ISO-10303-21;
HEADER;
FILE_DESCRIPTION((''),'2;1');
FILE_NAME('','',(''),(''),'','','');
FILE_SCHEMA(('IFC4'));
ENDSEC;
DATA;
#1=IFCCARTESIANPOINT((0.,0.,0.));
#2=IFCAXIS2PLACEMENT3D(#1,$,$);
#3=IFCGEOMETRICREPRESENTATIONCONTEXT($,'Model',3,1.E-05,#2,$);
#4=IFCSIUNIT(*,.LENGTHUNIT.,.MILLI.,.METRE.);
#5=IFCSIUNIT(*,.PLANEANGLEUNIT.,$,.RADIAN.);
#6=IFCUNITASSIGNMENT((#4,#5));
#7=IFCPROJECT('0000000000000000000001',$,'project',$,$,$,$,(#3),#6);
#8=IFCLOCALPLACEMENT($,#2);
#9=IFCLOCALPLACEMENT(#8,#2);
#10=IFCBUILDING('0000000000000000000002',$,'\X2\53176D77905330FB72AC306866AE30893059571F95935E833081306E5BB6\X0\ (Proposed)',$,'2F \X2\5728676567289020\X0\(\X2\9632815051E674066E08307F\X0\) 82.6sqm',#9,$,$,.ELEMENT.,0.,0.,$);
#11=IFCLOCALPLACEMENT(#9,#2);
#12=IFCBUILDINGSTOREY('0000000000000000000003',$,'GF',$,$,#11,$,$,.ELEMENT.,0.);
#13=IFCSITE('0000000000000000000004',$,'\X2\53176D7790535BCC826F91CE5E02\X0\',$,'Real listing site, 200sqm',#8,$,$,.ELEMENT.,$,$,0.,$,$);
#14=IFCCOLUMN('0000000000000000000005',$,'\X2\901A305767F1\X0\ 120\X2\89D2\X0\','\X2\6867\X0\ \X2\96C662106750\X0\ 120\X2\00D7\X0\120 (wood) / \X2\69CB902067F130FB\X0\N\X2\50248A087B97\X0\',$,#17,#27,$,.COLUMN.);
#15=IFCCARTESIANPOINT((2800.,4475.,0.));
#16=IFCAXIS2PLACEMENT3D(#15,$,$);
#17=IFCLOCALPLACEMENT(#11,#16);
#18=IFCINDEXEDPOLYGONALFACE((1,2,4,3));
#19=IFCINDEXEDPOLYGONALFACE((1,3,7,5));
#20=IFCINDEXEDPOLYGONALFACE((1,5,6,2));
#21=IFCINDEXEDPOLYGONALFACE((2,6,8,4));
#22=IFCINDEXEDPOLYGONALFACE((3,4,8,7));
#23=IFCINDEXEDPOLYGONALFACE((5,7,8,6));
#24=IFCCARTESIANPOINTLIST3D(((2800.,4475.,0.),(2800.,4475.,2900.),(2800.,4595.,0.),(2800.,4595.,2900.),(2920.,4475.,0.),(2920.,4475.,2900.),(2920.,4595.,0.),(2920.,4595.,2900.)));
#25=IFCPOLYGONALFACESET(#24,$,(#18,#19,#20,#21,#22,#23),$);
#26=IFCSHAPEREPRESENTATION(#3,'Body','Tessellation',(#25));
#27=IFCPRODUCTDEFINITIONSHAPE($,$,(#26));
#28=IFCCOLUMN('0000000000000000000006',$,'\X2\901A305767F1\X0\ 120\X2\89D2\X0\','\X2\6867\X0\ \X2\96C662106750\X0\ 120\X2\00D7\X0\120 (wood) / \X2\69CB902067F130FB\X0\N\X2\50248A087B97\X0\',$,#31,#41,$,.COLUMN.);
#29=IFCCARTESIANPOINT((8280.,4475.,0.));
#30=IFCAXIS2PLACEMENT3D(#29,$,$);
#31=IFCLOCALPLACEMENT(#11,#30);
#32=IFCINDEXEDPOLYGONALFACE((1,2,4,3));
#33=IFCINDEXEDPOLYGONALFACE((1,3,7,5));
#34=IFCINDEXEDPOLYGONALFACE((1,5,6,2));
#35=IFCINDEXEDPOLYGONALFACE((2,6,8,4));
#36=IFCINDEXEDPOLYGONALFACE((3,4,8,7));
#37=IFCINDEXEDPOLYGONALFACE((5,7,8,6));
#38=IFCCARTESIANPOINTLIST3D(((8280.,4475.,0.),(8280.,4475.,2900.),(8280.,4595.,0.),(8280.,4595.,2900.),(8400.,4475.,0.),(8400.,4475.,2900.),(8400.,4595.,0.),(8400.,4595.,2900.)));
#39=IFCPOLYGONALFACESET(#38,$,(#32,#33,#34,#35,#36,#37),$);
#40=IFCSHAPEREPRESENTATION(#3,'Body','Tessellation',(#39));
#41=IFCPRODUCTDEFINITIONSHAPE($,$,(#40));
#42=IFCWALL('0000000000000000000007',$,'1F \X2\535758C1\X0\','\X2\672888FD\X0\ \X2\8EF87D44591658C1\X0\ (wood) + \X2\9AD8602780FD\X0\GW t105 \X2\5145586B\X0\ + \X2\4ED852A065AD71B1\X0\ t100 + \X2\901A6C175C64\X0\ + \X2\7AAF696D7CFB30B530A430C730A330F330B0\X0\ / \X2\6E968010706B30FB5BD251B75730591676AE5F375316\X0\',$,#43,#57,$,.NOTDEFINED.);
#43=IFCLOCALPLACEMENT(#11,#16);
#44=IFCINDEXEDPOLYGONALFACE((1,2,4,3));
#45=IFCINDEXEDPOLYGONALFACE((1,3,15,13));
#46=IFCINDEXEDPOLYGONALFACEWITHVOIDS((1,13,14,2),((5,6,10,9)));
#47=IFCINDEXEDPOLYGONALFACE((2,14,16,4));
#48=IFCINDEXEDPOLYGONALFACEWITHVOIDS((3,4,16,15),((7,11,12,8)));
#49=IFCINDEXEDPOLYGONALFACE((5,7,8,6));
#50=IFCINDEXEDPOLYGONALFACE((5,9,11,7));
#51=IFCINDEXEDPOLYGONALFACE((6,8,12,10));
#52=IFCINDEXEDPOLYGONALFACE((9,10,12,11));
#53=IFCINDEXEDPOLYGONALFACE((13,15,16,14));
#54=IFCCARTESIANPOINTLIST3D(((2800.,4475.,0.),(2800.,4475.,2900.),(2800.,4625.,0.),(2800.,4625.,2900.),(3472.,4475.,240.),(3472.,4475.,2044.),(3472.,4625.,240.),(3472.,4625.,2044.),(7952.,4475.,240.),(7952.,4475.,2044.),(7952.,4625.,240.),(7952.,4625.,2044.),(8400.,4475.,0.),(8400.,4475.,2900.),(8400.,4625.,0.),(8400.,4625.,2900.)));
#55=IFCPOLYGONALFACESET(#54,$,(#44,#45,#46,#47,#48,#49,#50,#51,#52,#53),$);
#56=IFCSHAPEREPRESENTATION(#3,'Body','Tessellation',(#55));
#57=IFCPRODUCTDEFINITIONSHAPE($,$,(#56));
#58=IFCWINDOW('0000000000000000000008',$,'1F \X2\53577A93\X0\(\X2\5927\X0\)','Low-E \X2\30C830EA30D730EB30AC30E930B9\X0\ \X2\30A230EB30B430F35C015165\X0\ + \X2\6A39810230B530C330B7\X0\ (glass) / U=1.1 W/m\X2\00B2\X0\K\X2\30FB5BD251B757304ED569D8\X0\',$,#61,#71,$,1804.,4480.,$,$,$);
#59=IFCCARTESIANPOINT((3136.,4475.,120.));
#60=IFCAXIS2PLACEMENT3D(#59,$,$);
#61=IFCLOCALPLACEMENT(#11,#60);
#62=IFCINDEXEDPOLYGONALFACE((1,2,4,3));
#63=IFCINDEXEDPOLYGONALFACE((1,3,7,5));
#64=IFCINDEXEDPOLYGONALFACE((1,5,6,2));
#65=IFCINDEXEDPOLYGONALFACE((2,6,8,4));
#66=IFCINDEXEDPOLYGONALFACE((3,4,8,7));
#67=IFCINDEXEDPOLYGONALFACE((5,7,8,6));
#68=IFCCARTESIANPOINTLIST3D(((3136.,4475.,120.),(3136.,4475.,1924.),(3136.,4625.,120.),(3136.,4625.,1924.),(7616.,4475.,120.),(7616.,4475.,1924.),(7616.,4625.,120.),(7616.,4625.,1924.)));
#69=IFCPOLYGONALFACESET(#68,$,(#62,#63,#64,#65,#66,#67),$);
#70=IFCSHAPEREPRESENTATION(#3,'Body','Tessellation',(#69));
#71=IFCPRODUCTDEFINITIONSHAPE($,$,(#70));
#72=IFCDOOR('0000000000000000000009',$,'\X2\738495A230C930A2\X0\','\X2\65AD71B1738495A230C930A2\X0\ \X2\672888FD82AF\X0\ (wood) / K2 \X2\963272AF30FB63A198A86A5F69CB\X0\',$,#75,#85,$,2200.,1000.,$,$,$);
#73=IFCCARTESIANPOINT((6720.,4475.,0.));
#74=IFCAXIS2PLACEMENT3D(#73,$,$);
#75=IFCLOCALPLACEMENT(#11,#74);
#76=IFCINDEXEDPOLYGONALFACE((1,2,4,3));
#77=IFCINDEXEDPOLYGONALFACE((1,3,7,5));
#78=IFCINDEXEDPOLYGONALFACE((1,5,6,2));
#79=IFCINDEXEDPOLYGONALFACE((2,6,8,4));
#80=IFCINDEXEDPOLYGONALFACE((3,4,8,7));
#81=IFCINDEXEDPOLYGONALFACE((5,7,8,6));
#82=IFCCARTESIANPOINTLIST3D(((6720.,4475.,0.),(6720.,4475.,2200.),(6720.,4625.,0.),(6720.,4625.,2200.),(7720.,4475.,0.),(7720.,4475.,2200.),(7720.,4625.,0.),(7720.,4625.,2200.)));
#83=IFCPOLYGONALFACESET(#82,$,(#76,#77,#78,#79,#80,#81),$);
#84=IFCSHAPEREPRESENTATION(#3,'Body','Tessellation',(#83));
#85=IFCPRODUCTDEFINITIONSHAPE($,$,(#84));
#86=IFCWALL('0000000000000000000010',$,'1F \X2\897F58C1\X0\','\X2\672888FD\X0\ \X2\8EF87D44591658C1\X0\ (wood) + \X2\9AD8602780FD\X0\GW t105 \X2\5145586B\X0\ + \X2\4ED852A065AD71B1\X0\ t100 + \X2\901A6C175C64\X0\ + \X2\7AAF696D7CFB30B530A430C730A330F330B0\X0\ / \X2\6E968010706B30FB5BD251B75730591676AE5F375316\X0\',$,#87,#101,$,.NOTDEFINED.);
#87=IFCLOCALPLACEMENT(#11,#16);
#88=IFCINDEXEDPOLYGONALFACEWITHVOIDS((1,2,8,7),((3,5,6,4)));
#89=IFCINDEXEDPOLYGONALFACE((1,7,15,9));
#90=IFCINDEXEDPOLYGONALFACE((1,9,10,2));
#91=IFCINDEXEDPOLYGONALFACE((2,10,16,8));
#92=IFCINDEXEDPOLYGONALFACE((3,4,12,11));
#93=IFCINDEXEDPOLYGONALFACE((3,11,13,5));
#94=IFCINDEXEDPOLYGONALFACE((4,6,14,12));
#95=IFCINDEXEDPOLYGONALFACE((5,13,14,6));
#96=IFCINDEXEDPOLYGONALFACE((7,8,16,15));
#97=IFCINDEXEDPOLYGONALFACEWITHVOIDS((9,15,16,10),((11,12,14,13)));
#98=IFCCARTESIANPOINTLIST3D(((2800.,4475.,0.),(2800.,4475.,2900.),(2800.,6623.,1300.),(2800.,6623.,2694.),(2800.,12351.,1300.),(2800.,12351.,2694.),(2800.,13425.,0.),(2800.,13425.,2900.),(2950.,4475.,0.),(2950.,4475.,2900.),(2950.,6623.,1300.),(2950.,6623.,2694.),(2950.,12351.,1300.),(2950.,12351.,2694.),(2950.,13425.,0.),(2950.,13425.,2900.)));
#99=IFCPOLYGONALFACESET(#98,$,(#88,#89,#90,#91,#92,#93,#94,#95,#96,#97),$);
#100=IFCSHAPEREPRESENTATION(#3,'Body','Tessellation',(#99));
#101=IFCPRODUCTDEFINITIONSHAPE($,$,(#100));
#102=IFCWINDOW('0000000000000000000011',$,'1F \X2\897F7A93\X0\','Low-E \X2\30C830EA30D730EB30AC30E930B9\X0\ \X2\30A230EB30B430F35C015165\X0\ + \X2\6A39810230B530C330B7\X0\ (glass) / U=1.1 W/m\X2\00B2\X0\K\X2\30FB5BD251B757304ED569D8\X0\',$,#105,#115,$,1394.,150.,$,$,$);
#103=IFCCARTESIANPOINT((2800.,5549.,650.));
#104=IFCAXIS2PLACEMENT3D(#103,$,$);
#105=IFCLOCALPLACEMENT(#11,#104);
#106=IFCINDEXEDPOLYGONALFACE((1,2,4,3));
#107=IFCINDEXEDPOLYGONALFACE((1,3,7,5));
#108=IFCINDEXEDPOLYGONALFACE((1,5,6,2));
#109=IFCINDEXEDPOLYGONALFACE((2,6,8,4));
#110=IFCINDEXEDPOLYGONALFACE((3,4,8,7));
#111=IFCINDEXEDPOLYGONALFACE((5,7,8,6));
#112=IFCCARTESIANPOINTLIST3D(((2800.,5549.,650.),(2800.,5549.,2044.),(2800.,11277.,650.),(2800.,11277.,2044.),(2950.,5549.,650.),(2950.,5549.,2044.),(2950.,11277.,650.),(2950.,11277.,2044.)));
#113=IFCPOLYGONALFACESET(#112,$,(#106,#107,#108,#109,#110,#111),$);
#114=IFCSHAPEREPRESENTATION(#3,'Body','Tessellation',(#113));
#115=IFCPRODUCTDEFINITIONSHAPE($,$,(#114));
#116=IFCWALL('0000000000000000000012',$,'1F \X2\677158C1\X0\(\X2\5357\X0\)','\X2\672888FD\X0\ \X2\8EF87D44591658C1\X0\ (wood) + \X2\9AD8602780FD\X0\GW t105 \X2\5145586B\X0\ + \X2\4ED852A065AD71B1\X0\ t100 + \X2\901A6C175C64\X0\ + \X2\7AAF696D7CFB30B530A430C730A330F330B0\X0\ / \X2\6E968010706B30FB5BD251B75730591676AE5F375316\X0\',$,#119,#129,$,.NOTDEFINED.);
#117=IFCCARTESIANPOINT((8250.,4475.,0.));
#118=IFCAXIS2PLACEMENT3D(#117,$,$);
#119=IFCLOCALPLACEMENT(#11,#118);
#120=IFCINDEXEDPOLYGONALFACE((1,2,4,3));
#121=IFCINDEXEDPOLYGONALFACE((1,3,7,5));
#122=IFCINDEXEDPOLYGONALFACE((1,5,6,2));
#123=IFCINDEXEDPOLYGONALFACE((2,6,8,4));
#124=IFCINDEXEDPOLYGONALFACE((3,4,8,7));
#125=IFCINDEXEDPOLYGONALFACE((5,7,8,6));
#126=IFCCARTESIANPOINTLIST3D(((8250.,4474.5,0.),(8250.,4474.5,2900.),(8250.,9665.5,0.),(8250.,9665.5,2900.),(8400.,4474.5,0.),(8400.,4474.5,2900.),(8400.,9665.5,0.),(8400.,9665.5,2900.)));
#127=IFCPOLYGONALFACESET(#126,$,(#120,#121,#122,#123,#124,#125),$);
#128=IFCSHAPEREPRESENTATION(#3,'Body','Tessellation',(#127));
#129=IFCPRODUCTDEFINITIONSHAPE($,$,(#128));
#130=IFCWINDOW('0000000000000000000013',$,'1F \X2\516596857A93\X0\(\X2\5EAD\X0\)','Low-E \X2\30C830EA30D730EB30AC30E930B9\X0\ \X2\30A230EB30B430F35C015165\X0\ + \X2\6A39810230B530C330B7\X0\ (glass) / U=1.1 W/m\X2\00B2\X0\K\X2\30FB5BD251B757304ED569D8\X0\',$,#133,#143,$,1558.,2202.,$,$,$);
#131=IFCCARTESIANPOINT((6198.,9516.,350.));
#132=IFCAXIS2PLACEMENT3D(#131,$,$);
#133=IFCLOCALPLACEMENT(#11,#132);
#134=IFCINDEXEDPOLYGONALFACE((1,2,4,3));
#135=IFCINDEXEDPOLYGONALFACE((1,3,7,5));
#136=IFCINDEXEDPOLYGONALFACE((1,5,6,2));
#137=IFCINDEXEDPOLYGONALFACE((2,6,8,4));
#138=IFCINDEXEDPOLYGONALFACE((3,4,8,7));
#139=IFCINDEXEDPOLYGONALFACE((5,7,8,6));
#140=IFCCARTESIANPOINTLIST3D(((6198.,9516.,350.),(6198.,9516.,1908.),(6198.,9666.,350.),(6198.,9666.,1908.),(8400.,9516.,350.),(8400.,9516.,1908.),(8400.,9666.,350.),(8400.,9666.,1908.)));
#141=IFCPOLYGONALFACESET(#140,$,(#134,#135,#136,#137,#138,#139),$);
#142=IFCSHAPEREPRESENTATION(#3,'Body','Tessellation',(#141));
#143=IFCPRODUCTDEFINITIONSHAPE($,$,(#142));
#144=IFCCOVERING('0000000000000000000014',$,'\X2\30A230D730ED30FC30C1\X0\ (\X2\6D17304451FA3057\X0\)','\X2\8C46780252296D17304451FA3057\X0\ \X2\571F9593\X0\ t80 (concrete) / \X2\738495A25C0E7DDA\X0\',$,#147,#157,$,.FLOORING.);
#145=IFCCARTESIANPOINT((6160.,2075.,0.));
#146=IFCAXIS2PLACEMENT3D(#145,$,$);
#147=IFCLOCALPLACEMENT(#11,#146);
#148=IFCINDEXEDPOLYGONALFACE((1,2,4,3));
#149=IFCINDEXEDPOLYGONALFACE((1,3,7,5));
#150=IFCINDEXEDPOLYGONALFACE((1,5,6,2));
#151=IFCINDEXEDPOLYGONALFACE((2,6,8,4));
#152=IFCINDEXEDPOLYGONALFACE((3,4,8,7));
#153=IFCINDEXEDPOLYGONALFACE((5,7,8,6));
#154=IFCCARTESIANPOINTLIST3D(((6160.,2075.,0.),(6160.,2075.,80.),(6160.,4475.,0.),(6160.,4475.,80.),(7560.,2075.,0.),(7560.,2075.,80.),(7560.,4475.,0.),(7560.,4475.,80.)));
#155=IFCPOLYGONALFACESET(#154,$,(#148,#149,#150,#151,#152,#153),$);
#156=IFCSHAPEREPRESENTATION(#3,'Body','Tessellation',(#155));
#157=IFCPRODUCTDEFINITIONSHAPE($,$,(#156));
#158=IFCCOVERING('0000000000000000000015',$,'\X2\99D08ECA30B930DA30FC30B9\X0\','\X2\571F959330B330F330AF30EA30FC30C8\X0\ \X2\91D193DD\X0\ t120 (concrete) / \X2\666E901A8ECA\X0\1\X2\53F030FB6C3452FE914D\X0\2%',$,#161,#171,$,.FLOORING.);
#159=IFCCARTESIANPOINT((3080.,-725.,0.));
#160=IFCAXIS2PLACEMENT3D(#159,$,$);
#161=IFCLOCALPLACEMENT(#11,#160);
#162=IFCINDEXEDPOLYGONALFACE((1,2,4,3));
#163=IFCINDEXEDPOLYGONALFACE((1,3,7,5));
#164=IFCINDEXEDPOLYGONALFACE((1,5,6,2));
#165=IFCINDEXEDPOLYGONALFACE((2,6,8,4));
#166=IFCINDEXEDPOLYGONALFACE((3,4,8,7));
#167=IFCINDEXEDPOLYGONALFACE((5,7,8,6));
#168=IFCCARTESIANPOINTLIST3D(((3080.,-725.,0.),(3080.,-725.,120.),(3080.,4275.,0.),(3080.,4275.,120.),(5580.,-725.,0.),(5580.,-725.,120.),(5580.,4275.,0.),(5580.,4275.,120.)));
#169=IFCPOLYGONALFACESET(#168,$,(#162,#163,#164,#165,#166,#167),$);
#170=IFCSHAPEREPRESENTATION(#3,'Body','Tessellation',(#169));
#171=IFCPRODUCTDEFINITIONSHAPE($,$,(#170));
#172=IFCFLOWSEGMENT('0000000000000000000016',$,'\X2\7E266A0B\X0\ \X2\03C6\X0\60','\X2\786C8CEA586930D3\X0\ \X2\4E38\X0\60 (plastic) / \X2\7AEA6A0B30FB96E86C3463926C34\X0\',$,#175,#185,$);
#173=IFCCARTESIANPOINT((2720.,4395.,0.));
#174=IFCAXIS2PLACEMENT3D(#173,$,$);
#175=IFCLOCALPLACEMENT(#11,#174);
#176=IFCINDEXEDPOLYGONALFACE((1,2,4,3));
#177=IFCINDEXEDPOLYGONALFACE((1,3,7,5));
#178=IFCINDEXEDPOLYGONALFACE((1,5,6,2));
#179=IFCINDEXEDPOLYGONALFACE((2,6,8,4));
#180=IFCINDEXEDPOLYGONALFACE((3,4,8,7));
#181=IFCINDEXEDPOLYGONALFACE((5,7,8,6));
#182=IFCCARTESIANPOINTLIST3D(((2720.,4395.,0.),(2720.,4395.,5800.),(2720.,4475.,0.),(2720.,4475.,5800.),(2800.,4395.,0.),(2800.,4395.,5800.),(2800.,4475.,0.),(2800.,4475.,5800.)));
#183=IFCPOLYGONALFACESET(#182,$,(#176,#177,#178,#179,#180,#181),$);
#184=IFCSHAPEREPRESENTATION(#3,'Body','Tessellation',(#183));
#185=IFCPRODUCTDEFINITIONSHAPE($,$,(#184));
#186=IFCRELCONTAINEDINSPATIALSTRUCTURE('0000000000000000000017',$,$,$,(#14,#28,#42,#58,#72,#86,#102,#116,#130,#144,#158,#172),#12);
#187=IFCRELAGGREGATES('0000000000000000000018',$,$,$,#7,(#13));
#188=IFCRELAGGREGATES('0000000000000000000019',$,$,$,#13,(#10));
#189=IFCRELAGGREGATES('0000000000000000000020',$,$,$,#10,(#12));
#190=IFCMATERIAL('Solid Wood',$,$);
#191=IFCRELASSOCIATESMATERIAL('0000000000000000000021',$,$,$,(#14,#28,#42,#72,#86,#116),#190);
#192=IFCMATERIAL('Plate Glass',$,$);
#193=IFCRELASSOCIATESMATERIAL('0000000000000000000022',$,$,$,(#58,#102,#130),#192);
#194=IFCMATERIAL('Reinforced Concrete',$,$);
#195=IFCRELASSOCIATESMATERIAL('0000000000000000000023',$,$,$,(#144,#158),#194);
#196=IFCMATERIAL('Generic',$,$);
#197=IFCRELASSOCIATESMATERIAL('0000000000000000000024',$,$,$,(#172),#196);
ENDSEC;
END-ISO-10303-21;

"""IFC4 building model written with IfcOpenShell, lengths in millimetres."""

from ifc_helpers import new_model, si_unit, frame, frame_2d, origin, place, context, project, spatial, rectangle, extrude, material, element, fill, save


model = new_model("IFC4")

# Units and contexts
model_context = context("Model", 3, precision=1e-05, world=origin())
ifc_project = project(units=[si_unit("LENGTHUNIT", "METRE", prefix="MILLI"), si_unit("PLANEANGLEUNIT", "RADIAN")], contexts=[model_context])

# Site, building, storey
site_placement = place(None, origin())
site = spatial("IfcSite", under=ifc_project, at=site_placement, Name="北海道富良野市", ObjectType="Real listing site, 200sqm", CompositionType="ELEMENT", RefElevation=0.0)
building_placement = place(site_placement, origin())
building = spatial("IfcBuilding", under=site, at=building_placement, Name="北海道・犬と暮らす土間広めの家 (Proposed)", ObjectType="2F 在来木造(防腐処理済み) 82.6sqm", CompositionType="ELEMENT", ElevationOfRefHeight=0.0, ElevationOfTerrain=0.0)
storey_placement = place(building_placement, origin())
storey = spatial("IfcBuildingStorey", under=building, at=storey_placement, Name="GF", CompositionType="ELEMENT", Elevation=0.0)

# Columns
ifc_material_1 = material(Name="Solid Wood")
column_1_placement = place(storey_placement, frame((2800.0, 4475.0, 0.0)))
element("IfcColumn", 1, at=column_1_placement, inside=storey, material=ifc_material_1, Name="通し柱 120角", Description="桧 集成材 120×120 (wood) / 構造柱・N値計算", PredefinedType="COLUMN", context=model_context, shape_type="SweptSolid", body=[
    extrude(rectangle(XDim=120.0, YDim=120.0, at=frame_2d((60.0, 60.0))), frame((2800.0, 4475.0, 0.0)), (0.0, 0.0, 1.0), 2900.0),
])
column_2_placement = place(storey_placement, frame((8280.0, 4475.0, 0.0)))
element("IfcColumn", 2, at=column_2_placement, inside=storey, material=ifc_material_1, Name="通し柱 120角", Description="桧 集成材 120×120 (wood) / 構造柱・N値計算", PredefinedType="COLUMN", context=model_context, shape_type="SweptSolid", body=[
    extrude(rectangle(XDim=120.0, YDim=120.0, at=frame_2d((60.0, 60.0))), frame((8280.0, 4475.0, 0.0)), (0.0, 0.0, 1.0), 2900.0),
])

# Shared definitions
ifc_material_2 = material(Name="Reinforced Concrete")

# Wall, openings, window, door
wall_1_placement = place(storey_placement, frame((2800.0, 4475.0, 0.0)))
wall_1 = element("IfcWall", 3, at=wall_1_placement, inside=storey, material=ifc_material_1, Name="1F 南壁", Description="木製 軸組外壁 (wood) + 高性能GW t105 充填 + 付加断熱 t100 + 通気層 + 窯業系サイディング / 準耐火・寒冷地外皮強化", PredefinedType="NOTDEFINED", context=model_context, shape_type="SweptSolid", body=[
    extrude(rectangle(XDim=5600.0, YDim=150.0, at=frame_2d((2800.0, 75.0))), frame((2800.0, 4475.0, 0.0)), (0.0, 0.0, 1.0), 2900.0),
])
opening_1_placement = place(storey_placement, frame((3136.0, 4475.0, 120.0)))
opening_1 = element("IfcOpeningElement", 4, at=opening_1_placement, cuts=wall_1, PredefinedType="NOTDEFINED", context=model_context, shape_type="SweptSolid", body=[
    extrude(rectangle(XDim=4480.0, YDim=150.0, at=frame_2d((2240.0, 75.0))), frame((3136.0, 4475.0, 120.0)), (0.0, 0.0, 1.0), 1804.0),
])
opening_2_placement = place(storey_placement, frame((6720.0, 4475.0, 0.0)))
opening_2 = element("IfcOpeningElement", 5, at=opening_2_placement, cuts=wall_1, PredefinedType="NOTDEFINED", context=model_context, shape_type="SweptSolid", body=[
    extrude(rectangle(XDim=1000.0, YDim=150.0, at=frame_2d((500.0, 75.0))), frame((6720.0, 4475.0, 0.0)), (0.0, 0.0, 1.0), 2200.0),
])
ifc_material_3 = material(Name="Plate Glass")
window_1_placement = place(storey_placement, frame((3136.0, 4475.0, 120.0)))
window_1 = element("IfcWindow", 6, at=window_1_placement, inside=storey, material=ifc_material_3, Name="1F 南窓(大)", Description="Low-E トリプルガラス アルゴン封入 + 樹脂サッシ (glass) / U=1.1 W/m²K・寒冷地仕様", OverallHeight=1804.0, OverallWidth=4480.0, context=model_context, shape_type="SweptSolid", body=[
    extrude(rectangle(XDim=4480.0, YDim=150.0, at=frame_2d((2240.0, 75.0))), frame((3136.0, 4475.0, 120.0)), (0.0, 0.0, 1.0), 1804.0),
])
fill(opening_1, window_1)
door_1_placement = place(storey_placement, frame((6720.0, 4475.0, 0.0)))
door_1 = element("IfcDoor", 7, at=door_1_placement, inside=storey, material=ifc_material_1, Name="玄関ドア", Description="断熱玄関ドア 木製芯 (wood) / K2 防犯・採風機構", OverallHeight=2200.0, OverallWidth=1000.0, context=model_context, shape_type="SweptSolid", body=[
    extrude(rectangle(XDim=1000.0, YDim=150.0, at=frame_2d((500.0, 75.0))), frame((6720.0, 4475.0, 0.0)), (0.0, 0.0, 1.0), 2200.0),
])
fill(opening_2, door_1)

# Walls, openings, windows
wall_2_placement = place(storey_placement, frame((2800.0, 4475.0, 0.0)))
wall_2 = element("IfcWall", 8, at=wall_2_placement, inside=storey, material=ifc_material_1, Name="1F 西壁", Description="木製 軸組外壁 (wood) + 高性能GW t105 充填 + 付加断熱 t100 + 通気層 + 窯業系サイディング / 準耐火・寒冷地外皮強化", PredefinedType="NOTDEFINED", context=model_context, shape_type="SweptSolid", body=[
    extrude(rectangle(XDim=150.0, YDim=8950.0, at=frame_2d((75.0, 4475.0))), frame((2800.0, 4475.0, 0.0)), (0.0, 0.0, 1.0), 2900.0),
])
opening_3_placement = place(storey_placement, frame((2800.0, 5549.0, 650.0)))
opening_3 = element("IfcOpeningElement", 9, at=opening_3_placement, cuts=wall_2, PredefinedType="NOTDEFINED", context=model_context, shape_type="SweptSolid", body=[
    extrude(rectangle(XDim=150.0, YDim=5728.0, at=frame_2d((75.0, 2864.0))), frame((2800.0, 5549.0, 650.0)), (0.0, 0.0, 1.0), 1394.0),
])
window_2_placement = place(storey_placement, frame((2800.0, 5549.0, 650.0)))
window_2 = element("IfcWindow", 10, at=window_2_placement, inside=storey, material=ifc_material_3, Name="1F 西窓", Description="Low-E トリプルガラス アルゴン封入 + 樹脂サッシ (glass) / U=1.1 W/m²K・寒冷地仕様", OverallHeight=1394.0, OverallWidth=150.0, context=model_context, shape_type="SweptSolid", body=[
    extrude(rectangle(XDim=150.0, YDim=5728.0, at=frame_2d((75.0, 2864.0))), frame((2800.0, 5549.0, 650.0)), (0.0, 0.0, 1.0), 1394.0),
])
fill(opening_3, window_2)
wall_3_placement = place(storey_placement, frame((8250.0, 4475.0, 0.0)))
wall_3 = element("IfcWall", 11, at=wall_3_placement, inside=storey, material=ifc_material_1, Name="1F 東壁(南)", Description="木製 軸組外壁 (wood) + 高性能GW t105 充填 + 付加断熱 t100 + 通気層 + 窯業系サイディング / 準耐火・寒冷地外皮強化", PredefinedType="NOTDEFINED", context=model_context, shape_type="SweptSolid", body=[
    extrude(rectangle(XDim=150.0, YDim=5191.0, at=frame_2d((75.0, 2595.0))), frame((8250.0, 4475.0, 0.0)), (0.0, 0.0, 1.0), 2900.0),
])
opening_4_placement = place(storey_placement, frame((6198.0, 9516.0, 350.0)))
opening_4 = element("IfcOpeningElement", 12, at=opening_4_placement, cuts=wall_3, PredefinedType="NOTDEFINED", context=model_context, shape_type="SweptSolid", body=[
    extrude(rectangle(XDim=2202.0, YDim=150.0, at=frame_2d((1101.0, 75.0))), frame((6198.0, 9516.0, 350.0)), (0.0, 0.0, 1.0), 1558.0),
])
window_3_placement = place(storey_placement, frame((6198.0, 9516.0, 350.0)))
window_3 = element("IfcWindow", 13, at=window_3_placement, inside=storey, material=ifc_material_3, Name="1F 入隅窓(庭)", Description="Low-E トリプルガラス アルゴン封入 + 樹脂サッシ (glass) / U=1.1 W/m²K・寒冷地仕様", OverallHeight=1558.0, OverallWidth=2202.0, context=model_context, shape_type="SweptSolid", body=[
    extrude(rectangle(XDim=2202.0, YDim=150.0, at=frame_2d((1101.0, 75.0))), frame((6198.0, 9516.0, 350.0)), (0.0, 0.0, 1.0), 1558.0),
])
fill(opening_4, window_3)

# Coverings
covering_1_placement = place(storey_placement, frame((6160.0, 2075.0, 0.0)))
element("IfcCovering", 14, at=covering_1_placement, inside=storey, material=ifc_material_2, Name="アプローチ (洗い出し)", Description="豆砂利洗い出し 土間 t80 (concrete) / 玄関導線", PredefinedType="FLOORING", context=model_context, shape_type="SweptSolid", body=[
    extrude(rectangle(XDim=1400.0, YDim=2400.0, at=frame_2d((700.0, 1200.0))), frame((6160.0, 2075.0, 0.0)), (0.0, 0.0, 1.0), 80.0),
])
covering_2_placement = place(storey_placement, frame((3080.0, -725.0, 0.0)))
element("IfcCovering", 15, at=covering_2_placement, inside=storey, material=ifc_material_2, Name="駐車スペース", Description="土間コンクリート 金鏝 t120 (concrete) / 普通車1台・水勾配2%", PredefinedType="FLOORING", context=model_context, shape_type="SweptSolid", body=[
    extrude(rectangle(XDim=2500.0, YDim=5000.0, at=frame_2d((1250.0, 2500.0))), frame((3080.0, -725.0, 0.0)), (0.0, 0.0, 1.0), 120.0),
])

# Flow segment
ifc_material_4 = material(Name="Generic")
flow_segment_1_placement = place(storey_placement, frame((2720.0, 4395.0, 0.0)))
element("IfcFlowSegment", 16, at=flow_segment_1_placement, inside=storey, material=ifc_material_4, Name="縦樋 φ60", Description="硬質塩ビ 丸60 (plastic) / 竪樋・雨水排水", context=model_context, shape_type="SweptSolid", body=[
    extrude(rectangle(XDim=80.0, YDim=80.0, at=frame_2d((40.0, 40.0))), frame((2720.0, 4395.0, 0.0)), (0.0, 0.0, 1.0), 5800.0),
])

save(model, "model.ifc")
